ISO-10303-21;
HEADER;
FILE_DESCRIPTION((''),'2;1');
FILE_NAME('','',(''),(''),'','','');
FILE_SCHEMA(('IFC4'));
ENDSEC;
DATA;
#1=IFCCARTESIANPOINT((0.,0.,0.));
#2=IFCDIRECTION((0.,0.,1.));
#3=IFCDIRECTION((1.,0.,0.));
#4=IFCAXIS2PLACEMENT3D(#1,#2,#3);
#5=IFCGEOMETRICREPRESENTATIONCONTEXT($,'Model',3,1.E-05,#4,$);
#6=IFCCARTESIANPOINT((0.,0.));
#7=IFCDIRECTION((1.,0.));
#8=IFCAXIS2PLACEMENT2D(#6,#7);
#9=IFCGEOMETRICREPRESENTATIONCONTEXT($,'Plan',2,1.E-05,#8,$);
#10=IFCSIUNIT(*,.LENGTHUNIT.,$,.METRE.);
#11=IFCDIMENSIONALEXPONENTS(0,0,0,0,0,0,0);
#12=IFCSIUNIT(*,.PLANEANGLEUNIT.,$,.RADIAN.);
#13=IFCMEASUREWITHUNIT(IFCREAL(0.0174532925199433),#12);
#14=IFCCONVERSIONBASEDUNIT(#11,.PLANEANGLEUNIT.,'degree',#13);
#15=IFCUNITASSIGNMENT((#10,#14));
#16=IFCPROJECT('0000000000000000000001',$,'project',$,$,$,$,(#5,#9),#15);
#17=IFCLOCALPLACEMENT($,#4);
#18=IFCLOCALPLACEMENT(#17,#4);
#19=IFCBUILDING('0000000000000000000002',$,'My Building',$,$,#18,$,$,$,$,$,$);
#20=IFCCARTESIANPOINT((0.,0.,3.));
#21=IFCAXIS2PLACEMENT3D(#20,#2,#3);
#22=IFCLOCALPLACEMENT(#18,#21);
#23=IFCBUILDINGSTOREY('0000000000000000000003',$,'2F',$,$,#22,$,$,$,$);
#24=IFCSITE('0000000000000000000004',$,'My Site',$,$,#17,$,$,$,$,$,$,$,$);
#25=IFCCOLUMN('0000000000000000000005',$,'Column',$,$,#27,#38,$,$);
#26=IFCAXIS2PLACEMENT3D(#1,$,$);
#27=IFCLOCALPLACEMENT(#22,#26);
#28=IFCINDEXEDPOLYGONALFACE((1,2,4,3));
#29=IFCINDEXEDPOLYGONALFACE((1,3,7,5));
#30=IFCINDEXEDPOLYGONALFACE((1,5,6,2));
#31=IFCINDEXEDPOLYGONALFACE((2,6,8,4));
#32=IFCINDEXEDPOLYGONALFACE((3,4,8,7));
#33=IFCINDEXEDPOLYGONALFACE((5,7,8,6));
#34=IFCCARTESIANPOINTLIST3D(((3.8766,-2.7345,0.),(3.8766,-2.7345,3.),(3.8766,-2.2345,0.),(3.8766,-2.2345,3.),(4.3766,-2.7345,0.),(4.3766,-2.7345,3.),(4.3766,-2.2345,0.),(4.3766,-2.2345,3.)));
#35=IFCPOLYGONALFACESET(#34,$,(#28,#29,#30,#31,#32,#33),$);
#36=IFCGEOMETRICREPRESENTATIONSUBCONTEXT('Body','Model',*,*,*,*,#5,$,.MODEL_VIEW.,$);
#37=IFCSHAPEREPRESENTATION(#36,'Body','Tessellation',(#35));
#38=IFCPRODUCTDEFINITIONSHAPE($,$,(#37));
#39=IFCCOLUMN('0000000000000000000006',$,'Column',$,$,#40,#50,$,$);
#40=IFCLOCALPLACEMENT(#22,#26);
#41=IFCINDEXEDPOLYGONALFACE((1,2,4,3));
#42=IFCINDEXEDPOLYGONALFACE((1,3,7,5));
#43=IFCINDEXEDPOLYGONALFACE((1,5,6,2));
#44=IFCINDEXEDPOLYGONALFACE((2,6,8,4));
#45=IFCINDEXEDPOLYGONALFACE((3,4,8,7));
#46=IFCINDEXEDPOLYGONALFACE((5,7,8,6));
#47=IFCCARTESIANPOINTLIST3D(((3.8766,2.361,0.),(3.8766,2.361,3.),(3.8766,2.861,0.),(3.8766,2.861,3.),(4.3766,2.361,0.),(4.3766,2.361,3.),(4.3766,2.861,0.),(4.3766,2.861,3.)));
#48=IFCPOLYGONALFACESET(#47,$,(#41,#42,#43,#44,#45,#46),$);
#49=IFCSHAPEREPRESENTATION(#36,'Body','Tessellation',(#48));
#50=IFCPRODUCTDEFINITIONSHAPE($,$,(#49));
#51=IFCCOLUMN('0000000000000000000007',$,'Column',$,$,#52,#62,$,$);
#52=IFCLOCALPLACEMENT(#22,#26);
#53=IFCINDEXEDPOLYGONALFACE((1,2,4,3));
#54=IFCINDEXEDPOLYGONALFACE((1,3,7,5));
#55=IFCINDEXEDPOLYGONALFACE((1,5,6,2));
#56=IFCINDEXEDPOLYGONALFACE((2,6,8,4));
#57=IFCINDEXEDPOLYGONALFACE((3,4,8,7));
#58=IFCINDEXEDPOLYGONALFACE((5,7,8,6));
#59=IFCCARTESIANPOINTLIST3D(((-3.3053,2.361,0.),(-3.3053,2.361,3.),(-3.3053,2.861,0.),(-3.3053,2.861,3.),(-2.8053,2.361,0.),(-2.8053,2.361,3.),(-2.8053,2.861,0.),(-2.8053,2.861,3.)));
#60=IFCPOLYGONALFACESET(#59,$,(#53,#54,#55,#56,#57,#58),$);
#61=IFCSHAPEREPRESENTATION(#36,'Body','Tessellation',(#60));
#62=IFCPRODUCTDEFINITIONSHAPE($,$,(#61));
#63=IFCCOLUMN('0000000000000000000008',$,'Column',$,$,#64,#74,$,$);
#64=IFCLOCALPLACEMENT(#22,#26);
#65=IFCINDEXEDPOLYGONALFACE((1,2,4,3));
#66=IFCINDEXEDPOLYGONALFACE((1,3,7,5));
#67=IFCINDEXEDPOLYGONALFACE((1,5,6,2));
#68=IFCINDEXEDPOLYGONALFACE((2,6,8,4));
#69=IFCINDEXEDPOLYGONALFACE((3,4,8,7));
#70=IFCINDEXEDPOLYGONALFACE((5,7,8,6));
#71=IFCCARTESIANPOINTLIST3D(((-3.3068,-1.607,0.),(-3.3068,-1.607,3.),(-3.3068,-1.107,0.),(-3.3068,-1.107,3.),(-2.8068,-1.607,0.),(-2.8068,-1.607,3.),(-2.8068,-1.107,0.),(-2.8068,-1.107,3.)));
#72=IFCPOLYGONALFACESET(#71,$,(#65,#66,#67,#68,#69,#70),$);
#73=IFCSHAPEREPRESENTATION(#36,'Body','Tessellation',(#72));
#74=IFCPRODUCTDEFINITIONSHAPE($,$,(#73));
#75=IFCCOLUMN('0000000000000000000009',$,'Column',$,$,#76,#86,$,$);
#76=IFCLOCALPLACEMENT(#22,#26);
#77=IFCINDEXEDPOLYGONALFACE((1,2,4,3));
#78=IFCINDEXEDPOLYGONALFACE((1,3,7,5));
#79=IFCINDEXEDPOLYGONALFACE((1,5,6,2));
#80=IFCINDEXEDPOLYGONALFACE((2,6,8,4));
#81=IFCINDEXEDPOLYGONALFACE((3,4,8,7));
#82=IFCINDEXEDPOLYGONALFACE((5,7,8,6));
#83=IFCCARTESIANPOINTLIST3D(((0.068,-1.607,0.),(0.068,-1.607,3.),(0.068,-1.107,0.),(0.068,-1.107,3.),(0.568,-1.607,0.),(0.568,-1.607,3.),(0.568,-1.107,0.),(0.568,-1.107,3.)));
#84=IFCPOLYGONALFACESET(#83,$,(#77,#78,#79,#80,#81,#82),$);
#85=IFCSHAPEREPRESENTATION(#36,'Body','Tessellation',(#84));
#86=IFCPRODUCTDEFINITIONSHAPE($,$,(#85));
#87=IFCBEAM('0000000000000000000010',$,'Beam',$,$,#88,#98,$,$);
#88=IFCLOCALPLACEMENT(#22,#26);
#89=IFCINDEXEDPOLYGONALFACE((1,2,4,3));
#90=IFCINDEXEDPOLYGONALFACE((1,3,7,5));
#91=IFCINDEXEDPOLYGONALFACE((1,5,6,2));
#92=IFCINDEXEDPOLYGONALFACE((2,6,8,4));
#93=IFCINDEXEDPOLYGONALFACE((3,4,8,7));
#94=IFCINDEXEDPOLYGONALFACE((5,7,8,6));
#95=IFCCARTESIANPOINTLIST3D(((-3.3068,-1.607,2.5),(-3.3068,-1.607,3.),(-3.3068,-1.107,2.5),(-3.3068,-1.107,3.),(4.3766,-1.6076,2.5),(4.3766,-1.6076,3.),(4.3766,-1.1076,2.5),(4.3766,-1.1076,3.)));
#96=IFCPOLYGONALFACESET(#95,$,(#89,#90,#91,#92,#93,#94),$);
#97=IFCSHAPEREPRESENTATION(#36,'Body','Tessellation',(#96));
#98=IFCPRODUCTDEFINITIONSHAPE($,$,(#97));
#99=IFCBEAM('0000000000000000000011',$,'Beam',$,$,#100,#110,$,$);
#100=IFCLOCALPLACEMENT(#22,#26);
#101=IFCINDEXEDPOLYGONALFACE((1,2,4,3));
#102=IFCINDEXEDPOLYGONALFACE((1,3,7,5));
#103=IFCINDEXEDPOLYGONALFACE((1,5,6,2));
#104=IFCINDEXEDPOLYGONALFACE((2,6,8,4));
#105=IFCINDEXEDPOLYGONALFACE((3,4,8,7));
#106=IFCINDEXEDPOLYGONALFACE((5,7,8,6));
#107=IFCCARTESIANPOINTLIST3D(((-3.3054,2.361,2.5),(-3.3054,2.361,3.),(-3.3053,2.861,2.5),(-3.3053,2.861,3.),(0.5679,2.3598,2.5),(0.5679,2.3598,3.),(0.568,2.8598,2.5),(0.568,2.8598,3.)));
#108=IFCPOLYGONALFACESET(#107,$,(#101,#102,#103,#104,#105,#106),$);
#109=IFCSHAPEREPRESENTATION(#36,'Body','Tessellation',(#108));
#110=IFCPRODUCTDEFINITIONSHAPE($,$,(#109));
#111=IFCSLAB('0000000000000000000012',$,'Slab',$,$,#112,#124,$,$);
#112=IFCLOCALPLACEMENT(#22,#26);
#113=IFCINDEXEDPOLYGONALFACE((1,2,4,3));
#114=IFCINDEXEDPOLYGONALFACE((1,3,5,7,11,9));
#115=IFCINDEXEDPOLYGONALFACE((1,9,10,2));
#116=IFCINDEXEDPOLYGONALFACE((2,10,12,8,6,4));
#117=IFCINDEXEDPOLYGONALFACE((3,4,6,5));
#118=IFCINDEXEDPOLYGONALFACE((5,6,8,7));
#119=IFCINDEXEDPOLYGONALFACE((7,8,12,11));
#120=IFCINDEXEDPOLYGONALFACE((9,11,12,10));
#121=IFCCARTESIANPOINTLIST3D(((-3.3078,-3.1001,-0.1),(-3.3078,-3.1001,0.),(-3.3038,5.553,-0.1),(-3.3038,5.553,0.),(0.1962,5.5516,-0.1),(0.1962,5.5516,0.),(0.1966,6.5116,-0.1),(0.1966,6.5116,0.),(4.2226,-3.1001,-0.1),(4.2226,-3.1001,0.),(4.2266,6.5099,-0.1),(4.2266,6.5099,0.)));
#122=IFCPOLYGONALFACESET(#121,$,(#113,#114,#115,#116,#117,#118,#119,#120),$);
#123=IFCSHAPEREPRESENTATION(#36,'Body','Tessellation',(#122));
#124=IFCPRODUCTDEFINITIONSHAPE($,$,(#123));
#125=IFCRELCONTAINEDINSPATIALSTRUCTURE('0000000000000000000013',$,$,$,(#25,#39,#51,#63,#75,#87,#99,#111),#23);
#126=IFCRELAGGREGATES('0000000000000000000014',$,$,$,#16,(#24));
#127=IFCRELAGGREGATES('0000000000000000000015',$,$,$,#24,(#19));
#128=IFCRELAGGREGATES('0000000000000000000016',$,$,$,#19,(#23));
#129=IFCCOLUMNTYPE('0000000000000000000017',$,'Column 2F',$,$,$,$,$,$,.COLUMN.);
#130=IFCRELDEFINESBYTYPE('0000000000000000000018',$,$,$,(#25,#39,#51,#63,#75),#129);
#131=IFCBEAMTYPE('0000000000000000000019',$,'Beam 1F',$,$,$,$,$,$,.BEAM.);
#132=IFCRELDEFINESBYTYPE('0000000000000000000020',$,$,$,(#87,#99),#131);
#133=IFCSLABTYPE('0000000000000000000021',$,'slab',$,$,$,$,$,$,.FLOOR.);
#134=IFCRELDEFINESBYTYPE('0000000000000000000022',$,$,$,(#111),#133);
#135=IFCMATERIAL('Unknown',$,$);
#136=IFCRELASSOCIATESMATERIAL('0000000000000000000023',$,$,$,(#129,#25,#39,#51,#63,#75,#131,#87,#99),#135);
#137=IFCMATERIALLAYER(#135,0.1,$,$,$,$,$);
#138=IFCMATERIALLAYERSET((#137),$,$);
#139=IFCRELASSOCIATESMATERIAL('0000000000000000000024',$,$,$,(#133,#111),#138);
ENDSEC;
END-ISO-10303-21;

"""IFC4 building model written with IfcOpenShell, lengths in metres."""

from ifc_helpers import new_model, entity, si_unit, converted_unit, frame, origin_with_axes, origin_2d_with_axis, place, context, subcontext, project, spatial, indexed_curve, rectangle, outline, extrude, material, layer, layer_set, layer_usage, material_profile, profile_set, profile_usage, type_object, element, save


model = new_model("IFC4")

# Units and contexts
model_context = context("Model", 3, precision=1e-05, world=origin_with_axes())
plan_context = context("Plan", 2, precision=1e-05, world=origin_2d_with_axis())
body_context_1 = subcontext(model_context, "Body", "Model", "MODEL_VIEW")
ifc_project = project(units=[si_unit("LENGTHUNIT", "METRE"), converted_unit("PLANEANGLEUNIT", "degree", entity("IfcReal", 0.0174532925199433), si_unit("PLANEANGLEUNIT", "RADIAN"), dimensions=[0, 0, 0, 0, 0, 0, 0])], contexts=[model_context, plan_context])

# Site, building, storey
site_placement = place(None, origin_with_axes())
site = spatial("IfcSite", under=ifc_project, at=site_placement, Name="My Site")
building_placement = place(site_placement, origin_with_axes())
building = spatial("IfcBuilding", under=site, at=building_placement, Name="My Building")
storey_placement = place(building_placement, frame((0.0, 0.0, 3.0), z_axis=(0.0, 0.0, 1.0), x_axis=(1.0, 0.0, 0.0)))
storey = spatial("IfcBuildingStorey", under=building, at=storey_placement, Name="2F")

# Columns
ifc_material = material(Name="Unknown")
ifc_material_profile_1 = material_profile(ifc_material, rectangle(XDim=0.5, YDim=0.5))
ifc_profile_set_1 = profile_set([ifc_material_profile_1])
ifc_profile_usage_1 = profile_usage(ifc_profile_set_1, cardinal=1)
column_type = type_object("IfcColumnType", Name="Column 2F", PredefinedType="COLUMN", material=ifc_profile_set_1)
column_1_placement = place(storey_placement, frame((4.3766, -2.7345, 0.0), z_axis=(0.0, 0.0, 1.0), x_axis=(1.0, 0.0, 0.0)))
element("IfcColumn", 1, at=column_1_placement, inside=storey, type_object=column_type, material=ifc_profile_usage_1, Name="Column", context=body_context_1, shape_type="SweptSolid", body=[
    extrude(rectangle(XDim=0.5, YDim=0.5), frame((-0.25, 0.25, 0.0), z_axis=(0.0, 0.0, 1.0), x_axis=(1.0, 0.0, 0.0)), (0.0, 0.0, 1.0), 3.0),
])
ifc_profile_usage_2 = profile_usage(ifc_profile_set_1, cardinal=1)
column_2_placement = place(storey_placement, frame((4.3766, 2.361, 0.0), z_axis=(0.0, 0.0, 1.0), x_axis=(1.0, 0.0, 0.0)))
element("IfcColumn", 2, at=column_2_placement, inside=storey, type_object=column_type, material=ifc_profile_usage_2, Name="Column", context=body_context_1, shape_type="SweptSolid", body=[
    extrude(rectangle(XDim=0.5, YDim=0.5), frame((-0.25, 0.25, 0.0), z_axis=(0.0, 0.0, 1.0), x_axis=(1.0, 0.0, 0.0)), (0.0, 0.0, 1.0), 3.0),
])
ifc_profile_usage_3 = profile_usage(ifc_profile_set_1, cardinal=1)
column_3_placement = place(storey_placement, frame((-2.8053, 2.361, 0.0), z_axis=(0.0, 0.0, 1.0), x_axis=(1.0, 0.0, 0.0)))
element("IfcColumn", 3, at=column_3_placement, inside=storey, type_object=column_type, material=ifc_profile_usage_3, Name="Column", context=body_context_1, shape_type="SweptSolid", body=[
    extrude(rectangle(XDim=0.5, YDim=0.5), frame((-0.25, 0.25, 0.0), z_axis=(0.0, 0.0, 1.0), x_axis=(1.0, 0.0, 0.0)), (0.0, 0.0, 1.0), 3.0),
])
ifc_profile_usage_4 = profile_usage(ifc_profile_set_1, cardinal=3)
column_4_placement = place(storey_placement, frame((-3.3068, -1.607, 0.0), z_axis=(0.0, 0.0, 1.0), x_axis=(1.0, 0.0, 0.0)))
element("IfcColumn", 4, at=column_4_placement, inside=storey, type_object=column_type, material=ifc_profile_usage_4, Name="Column", context=body_context_1, shape_type="SweptSolid", body=[
    extrude(rectangle(XDim=0.5, YDim=0.5), frame((0.25, 0.25, 0.0), z_axis=(0.0, 0.0, 1.0), x_axis=(1.0, 0.0, 0.0)), (0.0, 0.0, 1.0), 3.0),
])
ifc_profile_usage_5 = profile_usage(ifc_profile_set_1, cardinal=3)
column_5_placement = place(storey_placement, frame((0.068, -1.607, 0.0), z_axis=(0.0, 0.0, 1.0), x_axis=(1.0, 0.0, 0.0)))
element("IfcColumn", 5, at=column_5_placement, inside=storey, type_object=column_type, material=ifc_profile_usage_5, Name="Column", context=body_context_1, shape_type="SweptSolid", body=[
    extrude(rectangle(XDim=0.5, YDim=0.5), frame((0.25, 0.25, 0.0), z_axis=(0.0, 0.0, 1.0), x_axis=(1.0, 0.0, 0.0)), (0.0, 0.0, 1.0), 3.0),
])

# Beams
ifc_material_profile_2 = material_profile(ifc_material, rectangle(XDim=0.5, YDim=0.5))
ifc_profile_set_2 = profile_set([ifc_material_profile_2])
ifc_profile_usage_6 = profile_usage(ifc_profile_set_2, cardinal=7)
beam_type = type_object("IfcBeamType", Name="Beam 1F", PredefinedType="BEAM", material=ifc_profile_set_2)
beam_1_placement = place(storey_placement, frame((-3.3068, -1.107, 3.0), z_axis=(1.0, -0.000082, 0.0), x_axis=(0.000082, 1.0, 0.0)))
element("IfcBeam", 6, at=beam_1_placement, inside=storey, type_object=beam_type, material=ifc_profile_usage_6, Name="Beam", context=body_context_1, shape_type="SweptSolid", body=[
    extrude(rectangle(XDim=0.5, YDim=0.5), frame((-0.25, -0.25, 0.0), z_axis=(0.0, 0.0, 1.0), x_axis=(1.0, 0.0, 0.0)), (0.0, 0.0, 1.0), 7.6834),
])
ifc_profile_usage_7 = profile_usage(ifc_profile_set_2, cardinal=7)
beam_2_placement = place(storey_placement, frame((-3.3053, 2.861, 3.0), z_axis=(1.0, -0.000317, 0.0), x_axis=(0.000317, 1.0, 0.0)))
element("IfcBeam", 7, at=beam_2_placement, inside=storey, type_object=beam_type, material=ifc_profile_usage_7, Name="Beam", context=body_context_1, shape_type="SweptSolid", body=[
    extrude(rectangle(XDim=0.5, YDim=0.5), frame((-0.25, -0.25, 0.0), z_axis=(0.0, 0.0, 1.0), x_axis=(1.0, 0.0, 0.0)), (0.0, 0.0, 1.0), 3.8733),
])

# Slab
ifc_layer_1 = layer(ifc_material, 0.1)
ifc_layer_set_1 = layer_set([ifc_layer_1])
ifc_layer_usage_1 = layer_usage(ifc_layer_set_1, "AXIS3", "POSITIVE", -0.1)
slab_type = type_object("IfcSlabType", Name="slab", PredefinedType="FLOOR", material=ifc_layer_set_1)
slab_placement = place(storey_placement, frame((-3.3078, -3.1001, 0.0), z_axis=(0.0, 0.0, 1.0), x_axis=(1.0, 0.0, 0.0)))
element("IfcSlab", 8, at=slab_placement, inside=storey, type_object=slab_type, material=ifc_layer_usage_1, Name="Slab", context=body_context_1, shape_type="SweptSolid", body=[
    extrude(outline(indexed_curve([(0.0, 0.0), (7.5304, 0.0), (7.5344, 9.61), (3.5044, 9.6117), (3.504, 8.6517), (0.004, 8.6531), (0.0, 0.0)])), frame((0.0, 0.0, -0.1), z_axis=(0.0, 0.0, 1.0), x_axis=(1.0, 0.0, 0.0)), (0.0, 0.0, 1.0), 0.1),
])

save(model, "model.ifc")
